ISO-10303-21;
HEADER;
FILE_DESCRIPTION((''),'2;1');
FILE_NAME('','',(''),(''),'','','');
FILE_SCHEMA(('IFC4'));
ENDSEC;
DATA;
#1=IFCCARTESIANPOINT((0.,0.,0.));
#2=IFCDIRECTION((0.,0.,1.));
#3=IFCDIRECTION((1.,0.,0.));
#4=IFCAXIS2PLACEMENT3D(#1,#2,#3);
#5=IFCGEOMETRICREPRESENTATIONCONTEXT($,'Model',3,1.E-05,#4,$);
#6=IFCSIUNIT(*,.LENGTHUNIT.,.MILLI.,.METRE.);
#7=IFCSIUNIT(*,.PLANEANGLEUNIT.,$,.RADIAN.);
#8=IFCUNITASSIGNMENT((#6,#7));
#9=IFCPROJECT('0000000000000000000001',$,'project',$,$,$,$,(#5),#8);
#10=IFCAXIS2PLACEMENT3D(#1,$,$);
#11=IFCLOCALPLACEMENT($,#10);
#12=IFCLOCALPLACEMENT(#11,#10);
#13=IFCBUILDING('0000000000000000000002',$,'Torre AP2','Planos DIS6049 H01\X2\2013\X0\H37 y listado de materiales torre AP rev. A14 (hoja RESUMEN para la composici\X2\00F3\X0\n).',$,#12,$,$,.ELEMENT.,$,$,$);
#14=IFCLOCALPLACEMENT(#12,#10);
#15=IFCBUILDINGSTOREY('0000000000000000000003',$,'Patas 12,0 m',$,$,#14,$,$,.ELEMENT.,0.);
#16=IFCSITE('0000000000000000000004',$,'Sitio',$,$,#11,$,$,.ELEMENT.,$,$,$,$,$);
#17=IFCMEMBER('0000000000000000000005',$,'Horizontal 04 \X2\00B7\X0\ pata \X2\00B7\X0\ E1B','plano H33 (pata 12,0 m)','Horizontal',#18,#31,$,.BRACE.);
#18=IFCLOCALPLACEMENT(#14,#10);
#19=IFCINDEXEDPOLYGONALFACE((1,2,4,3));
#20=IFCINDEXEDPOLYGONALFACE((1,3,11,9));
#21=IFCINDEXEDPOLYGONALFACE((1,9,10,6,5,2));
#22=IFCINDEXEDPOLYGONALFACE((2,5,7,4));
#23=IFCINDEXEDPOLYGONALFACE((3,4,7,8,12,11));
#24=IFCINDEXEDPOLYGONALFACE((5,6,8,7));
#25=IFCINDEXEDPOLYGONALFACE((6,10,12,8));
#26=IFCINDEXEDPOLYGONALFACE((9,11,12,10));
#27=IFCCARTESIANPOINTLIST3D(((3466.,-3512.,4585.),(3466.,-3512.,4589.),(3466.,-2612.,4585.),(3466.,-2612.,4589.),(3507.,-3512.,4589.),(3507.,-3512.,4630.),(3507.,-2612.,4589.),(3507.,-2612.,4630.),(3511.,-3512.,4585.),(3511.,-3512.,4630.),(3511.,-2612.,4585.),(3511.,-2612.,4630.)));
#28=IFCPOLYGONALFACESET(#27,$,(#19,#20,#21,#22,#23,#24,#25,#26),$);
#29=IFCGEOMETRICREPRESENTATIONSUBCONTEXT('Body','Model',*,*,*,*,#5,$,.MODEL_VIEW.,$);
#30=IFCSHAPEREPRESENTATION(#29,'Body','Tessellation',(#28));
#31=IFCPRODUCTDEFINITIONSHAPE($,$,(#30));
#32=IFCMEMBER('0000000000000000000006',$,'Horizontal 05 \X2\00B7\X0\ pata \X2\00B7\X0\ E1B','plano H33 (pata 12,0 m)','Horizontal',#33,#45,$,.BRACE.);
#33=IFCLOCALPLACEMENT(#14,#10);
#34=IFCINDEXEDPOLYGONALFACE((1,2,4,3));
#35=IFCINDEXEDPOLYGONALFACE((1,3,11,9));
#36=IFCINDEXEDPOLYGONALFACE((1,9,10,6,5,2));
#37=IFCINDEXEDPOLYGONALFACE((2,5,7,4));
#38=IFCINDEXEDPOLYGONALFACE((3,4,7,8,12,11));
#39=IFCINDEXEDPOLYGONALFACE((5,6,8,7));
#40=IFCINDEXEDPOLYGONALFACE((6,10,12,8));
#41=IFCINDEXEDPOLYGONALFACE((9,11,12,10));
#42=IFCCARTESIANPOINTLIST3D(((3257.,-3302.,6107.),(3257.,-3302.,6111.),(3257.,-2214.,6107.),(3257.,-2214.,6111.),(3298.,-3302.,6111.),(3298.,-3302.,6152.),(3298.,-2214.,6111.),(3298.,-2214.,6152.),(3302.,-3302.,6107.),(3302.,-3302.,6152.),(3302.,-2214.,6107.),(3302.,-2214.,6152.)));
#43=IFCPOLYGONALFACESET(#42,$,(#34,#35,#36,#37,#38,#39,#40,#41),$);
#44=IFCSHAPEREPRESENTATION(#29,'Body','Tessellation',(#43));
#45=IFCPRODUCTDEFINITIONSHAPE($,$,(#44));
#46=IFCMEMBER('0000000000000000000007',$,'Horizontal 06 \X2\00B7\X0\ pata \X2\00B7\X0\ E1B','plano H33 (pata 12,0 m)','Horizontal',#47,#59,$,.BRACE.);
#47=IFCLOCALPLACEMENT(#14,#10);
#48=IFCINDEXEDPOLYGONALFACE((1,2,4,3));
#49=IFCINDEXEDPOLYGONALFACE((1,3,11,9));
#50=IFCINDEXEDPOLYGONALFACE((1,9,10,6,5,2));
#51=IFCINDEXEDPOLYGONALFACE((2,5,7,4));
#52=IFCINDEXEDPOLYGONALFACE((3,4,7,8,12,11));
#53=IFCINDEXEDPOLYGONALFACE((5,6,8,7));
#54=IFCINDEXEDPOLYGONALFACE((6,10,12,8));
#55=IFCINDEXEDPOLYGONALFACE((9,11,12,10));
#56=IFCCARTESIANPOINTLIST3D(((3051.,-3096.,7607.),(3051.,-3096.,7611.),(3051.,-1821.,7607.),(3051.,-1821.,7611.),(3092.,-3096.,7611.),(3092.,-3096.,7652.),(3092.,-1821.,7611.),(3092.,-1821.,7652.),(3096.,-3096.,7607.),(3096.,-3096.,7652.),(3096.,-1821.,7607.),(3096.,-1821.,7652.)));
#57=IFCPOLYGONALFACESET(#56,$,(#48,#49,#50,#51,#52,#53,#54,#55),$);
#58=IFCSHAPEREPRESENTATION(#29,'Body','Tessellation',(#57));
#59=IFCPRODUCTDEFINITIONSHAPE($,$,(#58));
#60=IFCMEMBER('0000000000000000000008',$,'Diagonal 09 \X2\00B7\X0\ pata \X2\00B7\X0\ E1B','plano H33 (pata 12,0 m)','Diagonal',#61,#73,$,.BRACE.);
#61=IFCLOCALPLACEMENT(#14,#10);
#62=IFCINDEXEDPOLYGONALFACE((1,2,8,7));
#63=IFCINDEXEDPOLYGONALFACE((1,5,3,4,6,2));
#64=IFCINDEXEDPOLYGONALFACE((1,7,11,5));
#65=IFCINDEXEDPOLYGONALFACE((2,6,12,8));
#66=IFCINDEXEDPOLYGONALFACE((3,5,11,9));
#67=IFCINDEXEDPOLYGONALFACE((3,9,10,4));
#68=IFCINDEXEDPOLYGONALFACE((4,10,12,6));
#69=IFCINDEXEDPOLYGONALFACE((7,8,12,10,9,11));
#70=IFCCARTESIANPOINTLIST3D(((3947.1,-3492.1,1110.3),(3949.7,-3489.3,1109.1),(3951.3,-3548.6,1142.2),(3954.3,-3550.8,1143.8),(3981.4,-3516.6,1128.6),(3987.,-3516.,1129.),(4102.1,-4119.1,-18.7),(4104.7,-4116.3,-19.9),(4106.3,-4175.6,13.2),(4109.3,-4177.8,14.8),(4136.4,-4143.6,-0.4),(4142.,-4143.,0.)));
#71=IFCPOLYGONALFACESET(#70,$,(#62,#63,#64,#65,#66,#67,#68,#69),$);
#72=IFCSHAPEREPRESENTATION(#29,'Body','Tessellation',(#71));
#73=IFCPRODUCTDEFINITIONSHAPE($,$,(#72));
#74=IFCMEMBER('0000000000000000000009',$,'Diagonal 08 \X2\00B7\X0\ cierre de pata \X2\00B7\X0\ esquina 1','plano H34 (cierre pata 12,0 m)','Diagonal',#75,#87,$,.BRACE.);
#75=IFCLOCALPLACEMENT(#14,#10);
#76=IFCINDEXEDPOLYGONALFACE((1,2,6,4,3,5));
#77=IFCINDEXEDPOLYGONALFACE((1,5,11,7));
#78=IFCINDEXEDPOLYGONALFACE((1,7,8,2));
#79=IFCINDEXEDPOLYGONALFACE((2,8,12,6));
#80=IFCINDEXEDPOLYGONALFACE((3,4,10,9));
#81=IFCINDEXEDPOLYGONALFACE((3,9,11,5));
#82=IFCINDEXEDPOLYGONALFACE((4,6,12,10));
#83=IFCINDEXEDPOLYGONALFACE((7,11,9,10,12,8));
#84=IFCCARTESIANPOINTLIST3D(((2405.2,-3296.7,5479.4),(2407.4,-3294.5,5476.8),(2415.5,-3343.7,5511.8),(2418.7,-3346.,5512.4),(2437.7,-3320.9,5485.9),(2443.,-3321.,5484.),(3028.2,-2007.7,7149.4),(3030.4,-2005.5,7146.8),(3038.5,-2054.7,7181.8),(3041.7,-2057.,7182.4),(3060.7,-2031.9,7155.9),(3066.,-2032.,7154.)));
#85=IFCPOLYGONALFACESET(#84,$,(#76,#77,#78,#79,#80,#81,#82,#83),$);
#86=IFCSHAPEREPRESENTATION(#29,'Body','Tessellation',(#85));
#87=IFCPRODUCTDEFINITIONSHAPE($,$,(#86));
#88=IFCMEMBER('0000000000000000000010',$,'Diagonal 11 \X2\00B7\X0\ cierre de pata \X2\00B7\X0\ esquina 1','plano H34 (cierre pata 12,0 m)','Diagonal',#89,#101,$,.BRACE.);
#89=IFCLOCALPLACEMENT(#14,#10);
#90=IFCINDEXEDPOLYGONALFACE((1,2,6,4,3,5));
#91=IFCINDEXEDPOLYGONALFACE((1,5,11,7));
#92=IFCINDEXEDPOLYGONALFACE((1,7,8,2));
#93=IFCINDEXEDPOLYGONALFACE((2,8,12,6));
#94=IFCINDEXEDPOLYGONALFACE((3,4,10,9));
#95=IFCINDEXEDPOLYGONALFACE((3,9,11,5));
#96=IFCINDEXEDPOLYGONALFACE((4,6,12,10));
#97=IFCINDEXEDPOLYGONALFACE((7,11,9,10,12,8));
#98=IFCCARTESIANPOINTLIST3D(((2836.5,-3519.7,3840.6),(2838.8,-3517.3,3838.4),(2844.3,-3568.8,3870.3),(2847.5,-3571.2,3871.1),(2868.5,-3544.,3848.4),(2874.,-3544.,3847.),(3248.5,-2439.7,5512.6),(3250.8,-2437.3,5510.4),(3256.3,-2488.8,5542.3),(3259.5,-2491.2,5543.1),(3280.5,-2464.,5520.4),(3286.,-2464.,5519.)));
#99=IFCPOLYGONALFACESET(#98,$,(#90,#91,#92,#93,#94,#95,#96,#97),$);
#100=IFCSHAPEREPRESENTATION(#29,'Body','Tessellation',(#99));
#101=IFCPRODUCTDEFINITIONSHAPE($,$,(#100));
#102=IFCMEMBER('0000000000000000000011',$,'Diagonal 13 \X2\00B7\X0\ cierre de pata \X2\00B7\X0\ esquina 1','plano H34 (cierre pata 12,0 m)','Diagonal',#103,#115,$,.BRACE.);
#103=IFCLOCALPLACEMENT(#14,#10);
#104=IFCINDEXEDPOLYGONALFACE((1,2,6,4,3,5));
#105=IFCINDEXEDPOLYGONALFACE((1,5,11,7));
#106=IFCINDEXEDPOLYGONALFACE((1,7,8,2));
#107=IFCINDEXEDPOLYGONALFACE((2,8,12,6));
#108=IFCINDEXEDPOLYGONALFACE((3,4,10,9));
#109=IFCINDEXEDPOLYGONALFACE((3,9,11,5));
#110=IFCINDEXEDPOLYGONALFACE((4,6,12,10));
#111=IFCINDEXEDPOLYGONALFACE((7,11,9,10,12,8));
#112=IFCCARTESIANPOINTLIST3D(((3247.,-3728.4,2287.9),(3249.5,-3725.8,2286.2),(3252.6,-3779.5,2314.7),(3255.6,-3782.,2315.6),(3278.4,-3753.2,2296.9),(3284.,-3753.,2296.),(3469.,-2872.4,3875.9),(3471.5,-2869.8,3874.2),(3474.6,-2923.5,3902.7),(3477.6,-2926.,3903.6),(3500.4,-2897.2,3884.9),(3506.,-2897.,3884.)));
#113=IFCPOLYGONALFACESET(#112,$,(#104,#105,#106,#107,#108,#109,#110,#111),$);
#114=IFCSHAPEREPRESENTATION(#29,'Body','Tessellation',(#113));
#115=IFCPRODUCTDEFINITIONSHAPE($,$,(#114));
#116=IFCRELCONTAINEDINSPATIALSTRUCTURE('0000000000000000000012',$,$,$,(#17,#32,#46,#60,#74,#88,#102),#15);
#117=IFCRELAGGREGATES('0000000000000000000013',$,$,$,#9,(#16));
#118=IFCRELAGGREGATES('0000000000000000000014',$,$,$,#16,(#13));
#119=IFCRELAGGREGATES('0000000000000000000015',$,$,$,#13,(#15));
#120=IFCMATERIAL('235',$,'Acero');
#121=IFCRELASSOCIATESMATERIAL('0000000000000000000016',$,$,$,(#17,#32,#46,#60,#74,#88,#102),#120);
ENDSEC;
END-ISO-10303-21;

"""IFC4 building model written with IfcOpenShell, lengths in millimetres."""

from ifc_helpers import new_model, si_unit, frame, frame_2d, origin, origin_with_axes, place, context, subcontext, project, spatial, l_section, extrude, material, element, save


model = new_model("IFC4")

# Units and contexts
model_context = context("Model", 3, precision=1e-05, world=origin_with_axes())
body_context = subcontext(model_context, "Body", "Model", "MODEL_VIEW")
ifc_project = project(units=[si_unit("LENGTHUNIT", "METRE", prefix="MILLI"), si_unit("PLANEANGLEUNIT", "RADIAN")], contexts=[model_context])

# Site, building, storey
site_placement = place(None, origin())
site = spatial("IfcSite", under=ifc_project, at=site_placement, Name="Sitio", CompositionType="ELEMENT")
building_placement = place(site_placement, origin())
building = spatial("IfcBuilding", under=site, at=building_placement, Name="Torre AP2", Description="Planos DIS6049 H01–H37 y listado de materiales torre AP rev. A14 (hoja RESUMEN para la composición).", CompositionType="ELEMENT")
storey_placement = place(building_placement, origin())
storey = spatial("IfcBuildingStorey", under=building, at=storey_placement, Name="Patas 12,0 m", CompositionType="ELEMENT", Elevation=0.0)

# Members
ifc_material_1 = material(Name="235", Category="Acero")
member_1_placement = place(storey_placement, frame((3511.0, -3512.0, 4585.0), z_axis=(0.0, 1.0, 0.0), x_axis=(-1.0, 0.0, 0.0)))
element("IfcMember", 1, at=member_1_placement, inside=storey, material=ifc_material_1, Name="Horizontal 04 · pata · E1B", Description="plano H33 (pata 12,0 m)", ObjectType="Horizontal", PredefinedType="BRACE", context=body_context, shape_type="SweptSolid", body=[
    extrude(l_section(Depth=45.0, Width=45.0, Thickness=4.0, at=frame_2d((22.5, 22.5))), None, (0.0, 0.0, 1.0), 900.0),
])
member_2_placement = place(storey_placement, frame((3302.0, -3302.0, 6107.0), z_axis=(0.0, 1.0, 0.0), x_axis=(-1.0, 0.0, 0.0)))
element("IfcMember", 2, at=member_2_placement, inside=storey, material=ifc_material_1, Name="Horizontal 05 · pata · E1B", Description="plano H33 (pata 12,0 m)", ObjectType="Horizontal", PredefinedType="BRACE", context=body_context, shape_type="SweptSolid", body=[
    extrude(l_section(Depth=45.0, Width=45.0, Thickness=4.0, at=frame_2d((22.5, 22.5))), None, (0.0, 0.0, 1.0), 1088.0),
])
member_3_placement = place(storey_placement, frame((3096.0, -3096.0, 7607.0), z_axis=(0.0, 1.0, 0.0), x_axis=(-1.0, 0.0, 0.0)))
element("IfcMember", 3, at=member_3_placement, inside=storey, material=ifc_material_1, Name="Horizontal 06 · pata · E1B", Description="plano H33 (pata 12,0 m)", ObjectType="Horizontal", PredefinedType="BRACE", context=body_context, shape_type="SweptSolid", body=[
    extrude(l_section(Depth=45.0, Width=45.0, Thickness=4.0, at=frame_2d((22.5, 22.5))), None, (0.0, 0.0, 1.0), 1275.0),
])
member_4_placement = place(storey_placement, frame((4142.0, -4143.0, 0.0), z_axis=(-0.119168, 0.482052, 0.868001), x_axis=(-0.746182, 0.53324, -0.398583)))
element("IfcMember", 4, at=member_4_placement, inside=storey, material=ifc_material_1, Name="Diagonal 09 · pata · E1B", Description="plano H33 (pata 12,0 m)", ObjectType="Diagonal", PredefinedType="BRACE", context=body_context, shape_type="SweptSolid", body=[
    extrude(l_section(Depth=50.0, Width=50.0, Thickness=4.0, at=frame_2d((25.0, 25.0))), None, (0.0, 0.0, 1.0), 1300.7),
])
member_5_placement = place(storey_placement, frame((2443.0, -3321.0, 5484.0), z_axis=(0.283224, 0.585997, 0.759205), x_axis=(-0.792183, 0.58915, -0.159212)))
element("IfcMember", 5, at=member_5_placement, inside=storey, material=ifc_material_1, Name="Diagonal 08 · cierre de pata · esquina 1", Description="plano H34 (cierre pata 12,0 m)", ObjectType="Diagonal", PredefinedType="BRACE", context=body_context, shape_type="SweptSolid", body=[
    extrude(l_section(Depth=45.0, Width=45.0, Thickness=4.0, at=frame_2d((22.5, 22.5))), None, (0.0, 0.0, 1.0), 2199.7),
])
member_6_placement = place(storey_placement, frame((2874.0, -3544.0, 3847.0), z_axis=(0.20269, 0.531322, 0.822565), x_axis=(-0.781874, 0.593545, -0.190728)))
element("IfcMember", 6, at=member_6_placement, inside=storey, material=ifc_material_1, Name="Diagonal 11 · cierre de pata · esquina 1", Description="plano H34 (cierre pata 12,0 m)", ObjectType="Diagonal", PredefinedType="BRACE", context=body_context, shape_type="SweptSolid", body=[
    extrude(l_section(Depth=45.0, Width=45.0, Thickness=4.0, at=frame_2d((22.5, 22.5))), None, (0.0, 0.0, 1.0), 2032.7),
])
member_7_placement = place(storey_placement, frame((3284.0, -3753.0, 2296.0), z_axis=(0.122137, 0.470944, 0.873667), x_axis=(-0.766867, 0.603592, -0.218155)))
element("IfcMember", 7, at=member_7_placement, inside=storey, material=ifc_material_1, Name="Diagonal 13 · cierre de pata · esquina 1", Description="plano H34 (cierre pata 12,0 m)", ObjectType="Diagonal", PredefinedType="BRACE", context=body_context, shape_type="SweptSolid", body=[
    extrude(l_section(Depth=45.0, Width=45.0, Thickness=4.0, at=frame_2d((22.5, 22.5))), None, (0.0, 0.0, 1.0), 1817.6),
])

save(model, "model.ifc")
